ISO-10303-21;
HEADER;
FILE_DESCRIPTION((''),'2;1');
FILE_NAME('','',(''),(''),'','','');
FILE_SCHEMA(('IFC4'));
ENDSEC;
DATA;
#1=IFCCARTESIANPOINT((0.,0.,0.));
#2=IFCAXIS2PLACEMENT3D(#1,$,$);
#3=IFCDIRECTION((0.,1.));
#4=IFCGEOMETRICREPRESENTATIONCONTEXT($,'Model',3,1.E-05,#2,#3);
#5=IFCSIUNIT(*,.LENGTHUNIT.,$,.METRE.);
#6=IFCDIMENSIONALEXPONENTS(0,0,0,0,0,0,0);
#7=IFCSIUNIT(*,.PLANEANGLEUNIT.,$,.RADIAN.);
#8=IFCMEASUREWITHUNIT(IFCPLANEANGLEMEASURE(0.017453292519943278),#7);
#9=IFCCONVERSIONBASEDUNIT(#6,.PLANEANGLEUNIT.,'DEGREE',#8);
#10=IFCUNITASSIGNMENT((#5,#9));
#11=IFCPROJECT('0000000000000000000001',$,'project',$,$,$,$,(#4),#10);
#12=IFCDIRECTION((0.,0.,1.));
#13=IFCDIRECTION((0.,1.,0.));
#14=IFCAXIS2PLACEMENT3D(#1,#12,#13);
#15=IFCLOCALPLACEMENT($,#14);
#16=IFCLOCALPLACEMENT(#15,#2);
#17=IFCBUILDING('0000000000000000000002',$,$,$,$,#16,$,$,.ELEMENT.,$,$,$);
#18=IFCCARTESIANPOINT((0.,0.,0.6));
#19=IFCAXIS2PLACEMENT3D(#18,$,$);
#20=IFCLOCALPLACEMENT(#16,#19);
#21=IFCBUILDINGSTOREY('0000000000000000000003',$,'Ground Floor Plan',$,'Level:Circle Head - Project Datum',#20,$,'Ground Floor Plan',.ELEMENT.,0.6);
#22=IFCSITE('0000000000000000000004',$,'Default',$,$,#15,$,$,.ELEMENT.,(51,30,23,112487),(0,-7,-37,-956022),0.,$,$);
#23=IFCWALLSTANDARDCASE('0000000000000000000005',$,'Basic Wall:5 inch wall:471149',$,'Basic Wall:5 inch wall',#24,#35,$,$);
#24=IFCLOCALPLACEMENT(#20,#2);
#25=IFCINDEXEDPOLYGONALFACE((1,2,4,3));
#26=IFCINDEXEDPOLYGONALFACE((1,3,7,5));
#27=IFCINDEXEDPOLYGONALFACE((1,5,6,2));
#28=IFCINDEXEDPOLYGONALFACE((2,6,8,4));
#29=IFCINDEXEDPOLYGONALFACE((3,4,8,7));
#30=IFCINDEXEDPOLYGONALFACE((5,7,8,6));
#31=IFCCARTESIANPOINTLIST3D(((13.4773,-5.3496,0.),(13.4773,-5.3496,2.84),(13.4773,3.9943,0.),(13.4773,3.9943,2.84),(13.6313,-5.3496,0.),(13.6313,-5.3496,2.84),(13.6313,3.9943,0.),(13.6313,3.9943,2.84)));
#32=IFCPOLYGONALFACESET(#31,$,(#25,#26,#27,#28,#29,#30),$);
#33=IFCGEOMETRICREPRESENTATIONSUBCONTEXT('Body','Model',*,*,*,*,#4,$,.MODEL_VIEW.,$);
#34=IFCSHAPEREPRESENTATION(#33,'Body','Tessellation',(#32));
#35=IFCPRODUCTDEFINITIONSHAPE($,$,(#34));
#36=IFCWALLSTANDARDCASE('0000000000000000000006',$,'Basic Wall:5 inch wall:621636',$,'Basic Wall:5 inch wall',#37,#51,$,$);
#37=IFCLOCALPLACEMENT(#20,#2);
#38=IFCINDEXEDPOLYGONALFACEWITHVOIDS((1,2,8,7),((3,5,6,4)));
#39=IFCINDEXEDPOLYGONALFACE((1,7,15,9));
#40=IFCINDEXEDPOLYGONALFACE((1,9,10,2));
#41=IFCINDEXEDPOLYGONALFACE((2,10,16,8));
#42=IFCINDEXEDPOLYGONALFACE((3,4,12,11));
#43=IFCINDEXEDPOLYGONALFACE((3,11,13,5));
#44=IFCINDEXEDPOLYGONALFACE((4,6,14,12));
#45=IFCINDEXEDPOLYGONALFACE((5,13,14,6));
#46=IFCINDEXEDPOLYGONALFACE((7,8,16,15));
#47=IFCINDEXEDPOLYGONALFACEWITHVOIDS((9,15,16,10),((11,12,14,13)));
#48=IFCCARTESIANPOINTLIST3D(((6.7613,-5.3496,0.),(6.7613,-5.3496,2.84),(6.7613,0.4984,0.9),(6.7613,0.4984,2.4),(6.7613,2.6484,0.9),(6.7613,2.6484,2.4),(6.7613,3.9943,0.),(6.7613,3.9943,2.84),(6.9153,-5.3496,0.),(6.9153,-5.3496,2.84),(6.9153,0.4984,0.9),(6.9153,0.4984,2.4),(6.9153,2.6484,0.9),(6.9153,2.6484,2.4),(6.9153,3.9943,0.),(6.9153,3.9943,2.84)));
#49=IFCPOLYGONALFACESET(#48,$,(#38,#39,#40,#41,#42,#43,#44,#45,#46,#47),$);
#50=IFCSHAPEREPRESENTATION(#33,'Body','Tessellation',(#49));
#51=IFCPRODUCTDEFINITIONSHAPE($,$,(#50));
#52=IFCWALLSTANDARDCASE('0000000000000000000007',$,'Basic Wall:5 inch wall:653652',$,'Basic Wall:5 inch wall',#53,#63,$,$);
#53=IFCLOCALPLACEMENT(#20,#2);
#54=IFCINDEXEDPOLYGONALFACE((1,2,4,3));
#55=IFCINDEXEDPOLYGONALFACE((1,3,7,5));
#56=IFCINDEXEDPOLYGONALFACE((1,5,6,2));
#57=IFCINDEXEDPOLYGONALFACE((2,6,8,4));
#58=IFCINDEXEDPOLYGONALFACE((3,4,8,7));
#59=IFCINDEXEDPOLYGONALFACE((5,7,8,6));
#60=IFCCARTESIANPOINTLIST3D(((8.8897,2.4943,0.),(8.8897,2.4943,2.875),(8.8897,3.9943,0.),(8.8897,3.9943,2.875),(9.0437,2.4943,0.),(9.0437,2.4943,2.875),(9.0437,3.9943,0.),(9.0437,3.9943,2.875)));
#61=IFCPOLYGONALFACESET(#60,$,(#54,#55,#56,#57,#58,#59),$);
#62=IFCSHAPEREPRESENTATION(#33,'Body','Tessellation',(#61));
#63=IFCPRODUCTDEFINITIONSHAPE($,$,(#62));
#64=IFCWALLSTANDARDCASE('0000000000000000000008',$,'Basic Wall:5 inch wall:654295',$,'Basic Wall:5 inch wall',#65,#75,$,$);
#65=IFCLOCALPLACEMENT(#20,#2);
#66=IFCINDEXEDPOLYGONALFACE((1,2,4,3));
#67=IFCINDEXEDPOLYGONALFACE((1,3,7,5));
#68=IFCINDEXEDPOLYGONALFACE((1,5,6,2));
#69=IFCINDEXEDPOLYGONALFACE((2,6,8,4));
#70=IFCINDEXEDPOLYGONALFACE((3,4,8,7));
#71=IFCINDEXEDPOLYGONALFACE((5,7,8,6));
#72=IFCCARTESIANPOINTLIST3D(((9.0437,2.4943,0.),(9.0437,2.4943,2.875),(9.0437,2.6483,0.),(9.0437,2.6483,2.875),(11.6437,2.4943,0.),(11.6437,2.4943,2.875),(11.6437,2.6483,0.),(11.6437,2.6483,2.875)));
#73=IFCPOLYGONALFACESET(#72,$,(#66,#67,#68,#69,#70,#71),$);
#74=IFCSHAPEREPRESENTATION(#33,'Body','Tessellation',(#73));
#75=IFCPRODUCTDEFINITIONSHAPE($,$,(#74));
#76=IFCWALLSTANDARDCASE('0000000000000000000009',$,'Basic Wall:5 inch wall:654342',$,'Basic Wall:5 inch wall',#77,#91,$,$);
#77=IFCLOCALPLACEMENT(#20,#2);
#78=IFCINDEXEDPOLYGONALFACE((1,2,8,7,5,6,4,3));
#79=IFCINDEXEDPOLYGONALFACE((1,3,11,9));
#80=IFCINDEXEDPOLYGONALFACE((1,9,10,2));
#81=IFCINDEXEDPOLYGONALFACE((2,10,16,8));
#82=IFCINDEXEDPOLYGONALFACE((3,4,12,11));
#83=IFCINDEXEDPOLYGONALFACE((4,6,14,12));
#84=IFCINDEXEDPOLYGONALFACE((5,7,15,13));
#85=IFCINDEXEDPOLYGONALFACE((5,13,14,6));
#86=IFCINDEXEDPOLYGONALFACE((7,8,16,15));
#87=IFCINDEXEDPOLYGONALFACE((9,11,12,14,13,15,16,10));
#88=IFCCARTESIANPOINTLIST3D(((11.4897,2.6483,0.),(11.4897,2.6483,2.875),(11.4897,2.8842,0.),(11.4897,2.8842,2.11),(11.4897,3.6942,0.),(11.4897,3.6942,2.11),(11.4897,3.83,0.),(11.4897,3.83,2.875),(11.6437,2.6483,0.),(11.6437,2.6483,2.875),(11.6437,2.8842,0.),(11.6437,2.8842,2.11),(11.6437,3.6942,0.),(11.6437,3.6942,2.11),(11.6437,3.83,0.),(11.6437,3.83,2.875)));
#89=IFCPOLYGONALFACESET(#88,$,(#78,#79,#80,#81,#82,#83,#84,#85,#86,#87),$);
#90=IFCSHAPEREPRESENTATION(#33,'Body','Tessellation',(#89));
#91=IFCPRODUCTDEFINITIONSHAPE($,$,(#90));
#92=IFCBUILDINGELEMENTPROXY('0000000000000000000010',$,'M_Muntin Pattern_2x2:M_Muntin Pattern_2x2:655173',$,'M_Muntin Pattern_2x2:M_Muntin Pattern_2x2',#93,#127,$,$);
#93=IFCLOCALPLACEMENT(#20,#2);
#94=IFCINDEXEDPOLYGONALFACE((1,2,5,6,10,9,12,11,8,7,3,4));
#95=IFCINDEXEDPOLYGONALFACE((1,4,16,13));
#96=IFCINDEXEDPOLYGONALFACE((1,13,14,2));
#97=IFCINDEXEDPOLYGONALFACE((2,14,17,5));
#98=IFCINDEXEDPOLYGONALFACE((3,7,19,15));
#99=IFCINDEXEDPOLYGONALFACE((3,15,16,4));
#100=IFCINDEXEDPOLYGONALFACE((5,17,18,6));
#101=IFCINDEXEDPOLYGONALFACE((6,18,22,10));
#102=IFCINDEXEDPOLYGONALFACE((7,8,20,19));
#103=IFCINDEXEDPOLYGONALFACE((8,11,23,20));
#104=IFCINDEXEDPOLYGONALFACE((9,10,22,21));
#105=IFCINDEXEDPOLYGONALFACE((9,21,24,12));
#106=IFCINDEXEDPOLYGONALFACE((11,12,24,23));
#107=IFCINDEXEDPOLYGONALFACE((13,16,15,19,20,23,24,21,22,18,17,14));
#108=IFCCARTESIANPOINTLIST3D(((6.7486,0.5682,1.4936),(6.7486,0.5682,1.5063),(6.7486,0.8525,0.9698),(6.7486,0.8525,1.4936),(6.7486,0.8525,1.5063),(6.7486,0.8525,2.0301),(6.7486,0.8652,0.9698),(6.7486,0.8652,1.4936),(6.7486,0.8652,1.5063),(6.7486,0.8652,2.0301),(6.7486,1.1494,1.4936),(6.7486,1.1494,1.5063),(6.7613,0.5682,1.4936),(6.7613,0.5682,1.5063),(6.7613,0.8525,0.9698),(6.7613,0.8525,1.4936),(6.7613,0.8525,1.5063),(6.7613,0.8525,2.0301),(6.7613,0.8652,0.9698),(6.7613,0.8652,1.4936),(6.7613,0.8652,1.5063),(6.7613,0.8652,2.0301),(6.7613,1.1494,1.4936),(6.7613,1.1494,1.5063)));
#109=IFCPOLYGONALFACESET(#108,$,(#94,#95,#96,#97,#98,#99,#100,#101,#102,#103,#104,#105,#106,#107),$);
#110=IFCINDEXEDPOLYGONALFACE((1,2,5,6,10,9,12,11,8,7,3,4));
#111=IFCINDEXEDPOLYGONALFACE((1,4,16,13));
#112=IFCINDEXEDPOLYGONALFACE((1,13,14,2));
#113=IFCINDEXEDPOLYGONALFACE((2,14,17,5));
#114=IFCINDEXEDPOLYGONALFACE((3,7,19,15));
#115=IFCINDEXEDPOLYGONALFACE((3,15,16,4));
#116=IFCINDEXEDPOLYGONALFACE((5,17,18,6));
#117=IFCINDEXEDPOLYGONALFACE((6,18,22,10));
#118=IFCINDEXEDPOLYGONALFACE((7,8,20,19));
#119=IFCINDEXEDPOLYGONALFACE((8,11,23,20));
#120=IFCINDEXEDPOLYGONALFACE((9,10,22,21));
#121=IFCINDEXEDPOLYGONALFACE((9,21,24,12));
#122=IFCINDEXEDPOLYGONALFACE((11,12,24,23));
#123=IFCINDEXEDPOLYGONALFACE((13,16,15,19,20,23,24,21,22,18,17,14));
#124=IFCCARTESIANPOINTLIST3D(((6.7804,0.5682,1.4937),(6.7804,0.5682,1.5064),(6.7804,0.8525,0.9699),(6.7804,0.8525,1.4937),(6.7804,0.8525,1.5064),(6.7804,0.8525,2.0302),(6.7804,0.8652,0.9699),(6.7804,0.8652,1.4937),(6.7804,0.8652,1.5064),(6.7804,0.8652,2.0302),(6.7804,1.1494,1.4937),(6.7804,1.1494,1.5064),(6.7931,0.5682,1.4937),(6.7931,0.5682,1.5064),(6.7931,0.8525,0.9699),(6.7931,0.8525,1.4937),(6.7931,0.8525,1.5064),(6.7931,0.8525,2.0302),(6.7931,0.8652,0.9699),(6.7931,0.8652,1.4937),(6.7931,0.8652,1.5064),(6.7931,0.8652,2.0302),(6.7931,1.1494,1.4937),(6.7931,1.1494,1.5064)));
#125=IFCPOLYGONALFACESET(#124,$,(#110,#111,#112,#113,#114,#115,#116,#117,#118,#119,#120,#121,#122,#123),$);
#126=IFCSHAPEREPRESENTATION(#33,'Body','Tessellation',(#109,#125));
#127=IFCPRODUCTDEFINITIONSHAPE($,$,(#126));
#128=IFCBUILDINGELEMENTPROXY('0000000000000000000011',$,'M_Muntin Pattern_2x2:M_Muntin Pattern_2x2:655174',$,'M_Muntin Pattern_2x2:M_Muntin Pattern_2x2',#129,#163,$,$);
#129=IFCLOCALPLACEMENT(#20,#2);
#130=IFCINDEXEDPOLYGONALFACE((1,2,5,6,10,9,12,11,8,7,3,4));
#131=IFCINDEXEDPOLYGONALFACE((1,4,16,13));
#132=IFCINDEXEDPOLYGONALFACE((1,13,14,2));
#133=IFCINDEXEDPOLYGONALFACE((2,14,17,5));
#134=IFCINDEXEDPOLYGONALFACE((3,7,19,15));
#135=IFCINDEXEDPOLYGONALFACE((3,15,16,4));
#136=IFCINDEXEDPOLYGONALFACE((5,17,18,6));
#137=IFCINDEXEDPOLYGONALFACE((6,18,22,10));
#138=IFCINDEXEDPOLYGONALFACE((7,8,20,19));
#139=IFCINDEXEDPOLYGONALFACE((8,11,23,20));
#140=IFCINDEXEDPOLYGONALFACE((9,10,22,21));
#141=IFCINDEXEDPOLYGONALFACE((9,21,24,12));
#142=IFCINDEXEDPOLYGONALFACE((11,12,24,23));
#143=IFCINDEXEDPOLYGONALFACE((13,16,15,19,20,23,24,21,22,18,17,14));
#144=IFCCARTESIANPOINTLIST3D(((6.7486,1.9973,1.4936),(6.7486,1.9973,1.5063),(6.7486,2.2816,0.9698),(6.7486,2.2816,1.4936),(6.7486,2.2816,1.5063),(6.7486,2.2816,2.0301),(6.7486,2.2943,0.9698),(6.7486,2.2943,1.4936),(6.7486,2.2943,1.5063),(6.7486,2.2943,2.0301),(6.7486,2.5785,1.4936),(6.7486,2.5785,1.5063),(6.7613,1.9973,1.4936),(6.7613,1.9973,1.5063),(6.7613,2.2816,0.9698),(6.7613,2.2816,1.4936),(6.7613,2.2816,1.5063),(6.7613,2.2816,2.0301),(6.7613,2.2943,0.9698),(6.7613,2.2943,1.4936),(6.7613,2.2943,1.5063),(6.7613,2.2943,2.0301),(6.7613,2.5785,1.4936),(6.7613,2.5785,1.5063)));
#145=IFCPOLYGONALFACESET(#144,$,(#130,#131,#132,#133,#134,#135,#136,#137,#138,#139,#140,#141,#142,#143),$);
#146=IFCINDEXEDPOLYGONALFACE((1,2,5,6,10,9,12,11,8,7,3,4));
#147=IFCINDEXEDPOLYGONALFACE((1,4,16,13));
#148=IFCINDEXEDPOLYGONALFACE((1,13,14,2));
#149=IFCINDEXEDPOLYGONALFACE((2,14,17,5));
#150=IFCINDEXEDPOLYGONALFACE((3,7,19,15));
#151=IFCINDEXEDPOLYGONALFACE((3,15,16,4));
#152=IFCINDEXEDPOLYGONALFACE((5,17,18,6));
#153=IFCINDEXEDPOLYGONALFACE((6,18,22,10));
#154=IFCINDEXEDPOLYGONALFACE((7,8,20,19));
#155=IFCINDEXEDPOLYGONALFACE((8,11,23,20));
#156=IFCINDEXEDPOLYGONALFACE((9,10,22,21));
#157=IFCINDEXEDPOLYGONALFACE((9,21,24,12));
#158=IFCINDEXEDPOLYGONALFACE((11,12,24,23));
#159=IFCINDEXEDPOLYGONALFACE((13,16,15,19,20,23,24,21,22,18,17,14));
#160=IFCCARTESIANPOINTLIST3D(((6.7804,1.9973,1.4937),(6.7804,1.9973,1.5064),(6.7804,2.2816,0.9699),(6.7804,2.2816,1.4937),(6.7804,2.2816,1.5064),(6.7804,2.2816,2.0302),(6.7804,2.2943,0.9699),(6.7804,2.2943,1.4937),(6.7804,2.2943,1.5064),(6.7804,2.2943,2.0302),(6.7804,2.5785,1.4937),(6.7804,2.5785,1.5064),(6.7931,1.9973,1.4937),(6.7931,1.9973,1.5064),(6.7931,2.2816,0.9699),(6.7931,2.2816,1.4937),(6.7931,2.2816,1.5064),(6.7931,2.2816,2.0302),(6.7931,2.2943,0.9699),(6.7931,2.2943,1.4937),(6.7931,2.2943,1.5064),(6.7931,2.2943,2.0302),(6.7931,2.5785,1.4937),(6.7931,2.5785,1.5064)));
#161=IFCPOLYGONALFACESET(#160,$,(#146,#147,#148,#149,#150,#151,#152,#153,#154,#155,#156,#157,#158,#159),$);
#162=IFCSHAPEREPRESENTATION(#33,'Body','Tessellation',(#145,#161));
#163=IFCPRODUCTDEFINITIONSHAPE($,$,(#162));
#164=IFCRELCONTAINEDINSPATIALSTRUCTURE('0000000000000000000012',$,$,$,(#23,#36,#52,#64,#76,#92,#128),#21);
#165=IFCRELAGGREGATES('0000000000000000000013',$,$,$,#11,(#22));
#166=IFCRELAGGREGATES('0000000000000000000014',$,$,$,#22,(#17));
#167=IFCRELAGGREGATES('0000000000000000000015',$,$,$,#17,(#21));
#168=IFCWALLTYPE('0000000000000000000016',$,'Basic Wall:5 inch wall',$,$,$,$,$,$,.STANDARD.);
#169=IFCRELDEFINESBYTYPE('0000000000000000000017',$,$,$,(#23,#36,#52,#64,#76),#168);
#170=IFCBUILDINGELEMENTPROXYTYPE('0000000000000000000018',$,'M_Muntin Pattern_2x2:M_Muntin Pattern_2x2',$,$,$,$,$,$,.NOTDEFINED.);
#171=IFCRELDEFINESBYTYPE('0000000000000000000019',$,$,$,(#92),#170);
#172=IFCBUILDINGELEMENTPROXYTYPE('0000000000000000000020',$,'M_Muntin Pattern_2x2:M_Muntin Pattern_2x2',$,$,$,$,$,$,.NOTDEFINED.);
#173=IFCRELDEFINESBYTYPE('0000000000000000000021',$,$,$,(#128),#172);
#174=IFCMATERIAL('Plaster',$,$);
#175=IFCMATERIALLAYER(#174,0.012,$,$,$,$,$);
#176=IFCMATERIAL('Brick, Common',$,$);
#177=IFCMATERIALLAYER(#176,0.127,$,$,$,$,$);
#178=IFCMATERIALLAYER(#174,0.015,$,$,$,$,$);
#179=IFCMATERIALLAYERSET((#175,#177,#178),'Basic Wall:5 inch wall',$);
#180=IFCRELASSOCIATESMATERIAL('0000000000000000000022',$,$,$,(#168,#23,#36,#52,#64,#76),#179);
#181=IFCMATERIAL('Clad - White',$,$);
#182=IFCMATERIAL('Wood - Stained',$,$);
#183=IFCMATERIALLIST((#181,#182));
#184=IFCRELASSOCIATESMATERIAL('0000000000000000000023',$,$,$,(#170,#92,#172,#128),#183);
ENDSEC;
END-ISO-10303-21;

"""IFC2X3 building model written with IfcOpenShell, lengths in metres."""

from ifc_helpers import new_model, entity, si_unit, converted_unit, direction, frame, frame_2d, origin, place, context, subcontext, project, spatial, polyline, rectangle, outline, extrude, clip, bounded_halfspace, source, transform, mapped, material, material_list, layer, layer_set, layer_usage, type_object, type_shapes, element, save


model = new_model("IFC2X3")

# Units and contexts
model_context = context("Model", 3, precision=1e-05, world=origin(), true_north=direction((0.0, 1.0)))
body_context = subcontext(model_context, "Body", "Model", "MODEL_VIEW")
ifc_project = project(units=[si_unit("LENGTHUNIT", "METRE"), converted_unit("PLANEANGLEUNIT", "DEGREE", entity("IfcPlaneAngleMeasure", 0.017453292519943278), si_unit("PLANEANGLEUNIT", "RADIAN"), dimensions=[0, 0, 0, 0, 0, 0, 0])], contexts=[model_context])

# Site, building, storey
site_placement = place(None, frame((0.0, 0.0, 0.0), z_axis=(0.0, 0.0, 1.0), x_axis=(0.0, 1.0, 0.0)))
site = spatial("IfcSite", under=ifc_project, at=site_placement, Name="Default", CompositionType="ELEMENT", RefLatitude=(51, 30, 23, 112487), RefLongitude=(0, -7, -37, -956022), RefElevation=0.0)
building_placement = place(site_placement, origin())
building = spatial("IfcBuilding", under=site, at=building_placement, CompositionType="ELEMENT")
storey_placement = place(building_placement, frame((0.0, 0.0, 0.6)))
storey = spatial("IfcBuildingStorey", under=building, at=storey_placement, Name="Ground Floor Plan", ObjectType="Level:Circle Head - Project Datum", LongName="Ground Floor Plan", CompositionType="ELEMENT", Elevation=0.6)

# Wall
ifc_material_1 = material(Name="Plaster")
ifc_layer_1 = layer(ifc_material_1, 0.012)
ifc_material_2 = material(Name="Brick, Common")
ifc_layer_2 = layer(ifc_material_2, 0.127)
ifc_layer_3 = layer(ifc_material_1, 0.015)
ifc_layer_set = layer_set([ifc_layer_1, ifc_layer_2, ifc_layer_3], Name="Basic Wall:5 inch wall")
ifc_layer_usage_1 = layer_usage(ifc_layer_set, "AXIS2", "NEGATIVE", 0.077)
wall_type = type_object("IfcWallType", Name="Basic Wall:5 inch wall", PredefinedType="STANDARD", material=ifc_layer_set)
wall_1_placement = place(storey_placement, frame((13.5543, 3.9943, 0.0), z_axis=(0.0, 0.0, 1.0), x_axis=(0.0, -1.0, 0.0)))
element("IfcWallStandardCase", 1, at=wall_1_placement, inside=storey, type_object=wall_type, material=ifc_layer_usage_1, Name="Basic Wall:5 inch wall:471149", ObjectType="Basic Wall:5 inch wall", context=body_context, shape_type="SweptSolid", body=[
    extrude(rectangle(XDim=9.344, YDim=0.154, at=frame_2d((4.672, 0.0), x_axis=(-1.0, 0.0))), origin(), (0.0, 0.0, 1.0), 2.84),
])

# Wall, opening
ifc_layer_usage_2 = layer_usage(ifc_layer_set, "AXIS2", "NEGATIVE", 0.077)
wall_2_placement = place(storey_placement, frame((6.8383, 3.9943, 0.0), z_axis=(0.0, 0.0, 1.0), x_axis=(0.0, -1.0, 0.0)))
wall_2 = element("IfcWallStandardCase", 2, at=wall_2_placement, inside=storey, type_object=wall_type, material=ifc_layer_usage_2, Name="Basic Wall:5 inch wall:621636", ObjectType="Basic Wall:5 inch wall", context=body_context, shape_type="SweptSolid", body=[
    extrude(rectangle(XDim=9.344, YDim=0.154, at=frame_2d((4.672, 0.0), x_axis=(-1.0, 0.0))), origin(), (0.0, 0.0, 1.0), 2.84),
])
opening_1_placement = place(wall_2_placement, frame((3.496, 0.077, 0.9)))
element("IfcOpeningElement", 3, at=opening_1_placement, cuts=wall_2, ObjectType="Opening", context=body_context, shape_type="SweptSolid", body=[
    extrude(rectangle(XDim=1.5, YDim=2.15, at=frame_2d((0.75, 1.075), x_axis=(-1.0, 0.0))), frame((0.0, 0.0, 0.0), z_axis=(0.0, -1.0, 0.0), x_axis=(0.0, 0.0, 1.0)), (0.0, 0.0, 1.0), 0.154),
])

# Walls
ifc_layer_usage_3 = layer_usage(ifc_layer_set, "AXIS2", "NEGATIVE", 0.077)
wall_3_placement = place(storey_placement, frame((8.9667, 2.4943, 0.0), z_axis=(0.0, 0.0, 1.0), x_axis=(0.0, 1.0, 0.0)))
element("IfcWallStandardCase", 4, at=wall_3_placement, inside=storey, type_object=wall_type, material=ifc_layer_usage_3, Name="Basic Wall:5 inch wall:653652", ObjectType="Basic Wall:5 inch wall", context=body_context, shape_type="Clipping", body=[
    clip(extrude(rectangle(XDim=1.5, YDim=0.154, at=frame_2d((0.75, 0.0), x_axis=(-1.0, 0.0))), origin(), (0.0, 0.0, 1.0), 2.875), bounded_halfspace(frame((0.0, -0.077, 2.875), z_axis=(0.0, 0.0, -1.0), x_axis=(-1.0, 0.0, 0.0)), True, frame((0.0, -0.077, 2.875)), polyline([(0.0, 0.0), (0.154, 0.0), (1.5, 0.0), (1.5, 0.154), (0.0, 0.154), (0.0, 0.0)]))),
])
ifc_layer_usage_4 = layer_usage(ifc_layer_set, "AXIS2", "NEGATIVE", 0.077)
wall_4_placement = place(storey_placement, frame((9.0437, 2.5713, 0.0)))
element("IfcWallStandardCase", 5, at=wall_4_placement, inside=storey, type_object=wall_type, material=ifc_layer_usage_4, Name="Basic Wall:5 inch wall:654295", ObjectType="Basic Wall:5 inch wall", context=body_context, shape_type="Clipping", body=[
    clip(extrude(rectangle(XDim=2.6, YDim=0.154, at=frame_2d((1.3, 0.0), x_axis=(-1.0, 0.0))), origin(), (0.0, 0.0, 1.0), 2.875), bounded_halfspace(frame((0.0, -0.077, 2.875), z_axis=(0.0, 0.0, -1.0), x_axis=(0.0, -1.0, 0.0)), True, frame((0.0, -0.077, 2.875)), polyline([(0.0, 0.0), (2.4056, 0.0), (2.5596, 0.0), (2.6, 0.0), (2.6, 0.154), (2.446, 0.154), (0.0, 0.154), (0.0, 0.0)]))),
])

# Wall, opening
ifc_layer_usage_5 = layer_usage(ifc_layer_set, "AXIS2", "NEGATIVE", 0.077)
wall_5_placement = place(storey_placement, frame((11.5667, 2.6483, 0.0), z_axis=(0.0, 0.0, 1.0), x_axis=(0.0, 1.0, 0.0)))
wall_5 = element("IfcWallStandardCase", 6, at=wall_5_placement, inside=storey, type_object=wall_type, material=ifc_layer_usage_5, Name="Basic Wall:5 inch wall:654342", ObjectType="Basic Wall:5 inch wall", context=body_context, shape_type="Clipping", body=[
    clip(extrude(rectangle(XDim=1.1816, YDim=0.154, at=frame_2d((0.5908, 0.0), x_axis=(-1.0, 0.0))), origin(), (0.0, 0.0, 1.0), 2.875), bounded_halfspace(frame((0.0, -0.077, 2.875), z_axis=(0.0, 0.0, -1.0), x_axis=(-1.0, 0.0, 0.0)), True, frame((0.0, -0.077, 2.875)), polyline([(0.0, 0.0), (1.1816, 0.0), (1.1816, 0.154), (0.0, 0.154), (0.0, 0.0)]))),
])
opening_2_placement = place(wall_5_placement, frame((0.2358, -0.077, 0.0)))
element("IfcOpeningElement", 7, at=opening_2_placement, cuts=wall_5, ObjectType="Opening", context=body_context, shape_type="SweptSolid", body=[
    extrude(rectangle(XDim=2.11, YDim=0.81, at=frame_2d((1.055, 0.405), x_axis=(1.0, 0.0))), frame((0.0, 0.0, 0.0), z_axis=(0.0, 1.0, 0.0), x_axis=(0.0, 0.0, 1.0)), (0.0, 0.0, 1.0), 0.154),
])

# Building element proxies
ifc_material_3 = material(Name="Clad - White")
ifc_material_4 = material(Name="Wood - Stained")
ifc_material_list = material_list([ifc_material_3, ifc_material_4])
building_element_proxy_type_1 = type_object("IfcBuildingElementProxyType", Name="M_Muntin Pattern_2x2:M_Muntin Pattern_2x2", PredefinedType="NOTDEFINED", material=ifc_material_list)
shared_shape_1 = source(origin(), body_context, "Body", "SweptSolid", [
    extrude(outline(polyline([(0.0064, -0.0064), (0.5301, -0.0064), (0.5301, 0.0063), (0.0064, 0.0063), (0.0064, 0.2906), (-0.0063, 0.2906), (-0.0063, 0.0063), (-0.5302, 0.0063), (-0.5302, -0.0064), (-0.0063, -0.0064), (-0.0063, -0.2906), (0.0064, -0.2906), (0.0064, -0.0064)])), frame((0.0, 0.0095, 0.5301), z_axis=(0.0, 1.0, 0.0), x_axis=(0.0, 0.0, 1.0)), (0.0, 0.0, 1.0), 0.0127),
    extrude(outline(polyline([(0.0064, -0.0064), (0.5302, -0.0064), (0.5302, 0.0063), (0.0064, 0.0063), (0.0064, 0.2906), (-0.0063, 0.2906), (-0.0063, 0.0063), (-0.5302, 0.0063), (-0.5302, -0.0064), (-0.0063, -0.0064), (-0.0063, -0.2906), (0.0064, -0.2906), (0.0064, -0.0064)])), frame((0.0, -0.0222, 0.5302), z_axis=(0.0, 1.0, 0.0), x_axis=(0.0, 0.0, 1.0)), (0.0, 0.0, 1.0), 0.0127),
])
type_shapes(building_element_proxy_type_1, [shared_shape_1])
proxy_1_placement = place(storey_placement, frame((6.7708, 0.8588, 0.9699), z_axis=(0.0, 0.0, 1.0), x_axis=(0.0, 1.0, 0.0)))
element("IfcBuildingElementProxy", 8, at=proxy_1_placement, inside=storey, type_object=building_element_proxy_type_1, material=ifc_material_list, Name="M_Muntin Pattern_2x2:M_Muntin Pattern_2x2:655173", ObjectType="M_Muntin Pattern_2x2:M_Muntin Pattern_2x2", context=body_context, shape_type="MappedRepresentation", body=[
    mapped(shared_shape_1, transform((0.0, 0.0, 0.0), scale=1.0)),
])
building_element_proxy_type_2 = type_object("IfcBuildingElementProxyType", Name="M_Muntin Pattern_2x2:M_Muntin Pattern_2x2", PredefinedType="NOTDEFINED", material=ifc_material_list)
shared_shape_2 = source(origin(), body_context, "Body", "SweptSolid", [
    extrude(outline(polyline([(0.0064, -0.0064), (0.5301, -0.0064), (0.5301, 0.0063), (0.0064, 0.0063), (0.0064, 0.2906), (-0.0063, 0.2906), (-0.0063, 0.0063), (-0.5302, 0.0063), (-0.5302, -0.0064), (-0.0063, -0.0064), (-0.0063, -0.2906), (0.0064, -0.2906), (0.0064, -0.0064)])), frame((0.0, -0.0222, 0.5301), z_axis=(0.0, 1.0, 0.0), x_axis=(0.0, 0.0, 1.0)), (0.0, 0.0, 1.0), 0.0127),
    extrude(outline(polyline([(0.0064, -0.0064), (0.5302, -0.0064), (0.5302, 0.0063), (0.0064, 0.0063), (0.0064, 0.2906), (-0.0063, 0.2906), (-0.0063, 0.0063), (-0.5302, 0.0063), (-0.5302, -0.0064), (-0.0063, -0.0064), (-0.0063, -0.2906), (0.0064, -0.2906), (0.0064, -0.0064)])), frame((0.0, 0.0095, 0.5302), z_axis=(0.0, 1.0, 0.0), x_axis=(0.0, 0.0, 1.0)), (0.0, 0.0, 1.0), 0.0127),
])
type_shapes(building_element_proxy_type_2, [shared_shape_2])
for number, where, z_axis, x_axis, name in (
    (9, (6.7708, 2.2879, 0.9699), (0.0, 0.0, 1.0), (0.0, -1.0, 0.0), "M_Muntin Pattern_2x2:M_Muntin Pattern_2x2:655174"),
):
    element("IfcBuildingElementProxy", number, at=place(storey_placement, frame(where, z_axis=z_axis, x_axis=x_axis)), inside=storey, type_object=building_element_proxy_type_2, material=ifc_material_list, Name=name, ObjectType="M_Muntin Pattern_2x2:M_Muntin Pattern_2x2", context=body_context, shape_type="MappedRepresentation", body=[
        mapped(shared_shape_2, transform((0.0, 0.0, 0.0), scale=1.0)),
    ])

save(model, "model.ifc")
